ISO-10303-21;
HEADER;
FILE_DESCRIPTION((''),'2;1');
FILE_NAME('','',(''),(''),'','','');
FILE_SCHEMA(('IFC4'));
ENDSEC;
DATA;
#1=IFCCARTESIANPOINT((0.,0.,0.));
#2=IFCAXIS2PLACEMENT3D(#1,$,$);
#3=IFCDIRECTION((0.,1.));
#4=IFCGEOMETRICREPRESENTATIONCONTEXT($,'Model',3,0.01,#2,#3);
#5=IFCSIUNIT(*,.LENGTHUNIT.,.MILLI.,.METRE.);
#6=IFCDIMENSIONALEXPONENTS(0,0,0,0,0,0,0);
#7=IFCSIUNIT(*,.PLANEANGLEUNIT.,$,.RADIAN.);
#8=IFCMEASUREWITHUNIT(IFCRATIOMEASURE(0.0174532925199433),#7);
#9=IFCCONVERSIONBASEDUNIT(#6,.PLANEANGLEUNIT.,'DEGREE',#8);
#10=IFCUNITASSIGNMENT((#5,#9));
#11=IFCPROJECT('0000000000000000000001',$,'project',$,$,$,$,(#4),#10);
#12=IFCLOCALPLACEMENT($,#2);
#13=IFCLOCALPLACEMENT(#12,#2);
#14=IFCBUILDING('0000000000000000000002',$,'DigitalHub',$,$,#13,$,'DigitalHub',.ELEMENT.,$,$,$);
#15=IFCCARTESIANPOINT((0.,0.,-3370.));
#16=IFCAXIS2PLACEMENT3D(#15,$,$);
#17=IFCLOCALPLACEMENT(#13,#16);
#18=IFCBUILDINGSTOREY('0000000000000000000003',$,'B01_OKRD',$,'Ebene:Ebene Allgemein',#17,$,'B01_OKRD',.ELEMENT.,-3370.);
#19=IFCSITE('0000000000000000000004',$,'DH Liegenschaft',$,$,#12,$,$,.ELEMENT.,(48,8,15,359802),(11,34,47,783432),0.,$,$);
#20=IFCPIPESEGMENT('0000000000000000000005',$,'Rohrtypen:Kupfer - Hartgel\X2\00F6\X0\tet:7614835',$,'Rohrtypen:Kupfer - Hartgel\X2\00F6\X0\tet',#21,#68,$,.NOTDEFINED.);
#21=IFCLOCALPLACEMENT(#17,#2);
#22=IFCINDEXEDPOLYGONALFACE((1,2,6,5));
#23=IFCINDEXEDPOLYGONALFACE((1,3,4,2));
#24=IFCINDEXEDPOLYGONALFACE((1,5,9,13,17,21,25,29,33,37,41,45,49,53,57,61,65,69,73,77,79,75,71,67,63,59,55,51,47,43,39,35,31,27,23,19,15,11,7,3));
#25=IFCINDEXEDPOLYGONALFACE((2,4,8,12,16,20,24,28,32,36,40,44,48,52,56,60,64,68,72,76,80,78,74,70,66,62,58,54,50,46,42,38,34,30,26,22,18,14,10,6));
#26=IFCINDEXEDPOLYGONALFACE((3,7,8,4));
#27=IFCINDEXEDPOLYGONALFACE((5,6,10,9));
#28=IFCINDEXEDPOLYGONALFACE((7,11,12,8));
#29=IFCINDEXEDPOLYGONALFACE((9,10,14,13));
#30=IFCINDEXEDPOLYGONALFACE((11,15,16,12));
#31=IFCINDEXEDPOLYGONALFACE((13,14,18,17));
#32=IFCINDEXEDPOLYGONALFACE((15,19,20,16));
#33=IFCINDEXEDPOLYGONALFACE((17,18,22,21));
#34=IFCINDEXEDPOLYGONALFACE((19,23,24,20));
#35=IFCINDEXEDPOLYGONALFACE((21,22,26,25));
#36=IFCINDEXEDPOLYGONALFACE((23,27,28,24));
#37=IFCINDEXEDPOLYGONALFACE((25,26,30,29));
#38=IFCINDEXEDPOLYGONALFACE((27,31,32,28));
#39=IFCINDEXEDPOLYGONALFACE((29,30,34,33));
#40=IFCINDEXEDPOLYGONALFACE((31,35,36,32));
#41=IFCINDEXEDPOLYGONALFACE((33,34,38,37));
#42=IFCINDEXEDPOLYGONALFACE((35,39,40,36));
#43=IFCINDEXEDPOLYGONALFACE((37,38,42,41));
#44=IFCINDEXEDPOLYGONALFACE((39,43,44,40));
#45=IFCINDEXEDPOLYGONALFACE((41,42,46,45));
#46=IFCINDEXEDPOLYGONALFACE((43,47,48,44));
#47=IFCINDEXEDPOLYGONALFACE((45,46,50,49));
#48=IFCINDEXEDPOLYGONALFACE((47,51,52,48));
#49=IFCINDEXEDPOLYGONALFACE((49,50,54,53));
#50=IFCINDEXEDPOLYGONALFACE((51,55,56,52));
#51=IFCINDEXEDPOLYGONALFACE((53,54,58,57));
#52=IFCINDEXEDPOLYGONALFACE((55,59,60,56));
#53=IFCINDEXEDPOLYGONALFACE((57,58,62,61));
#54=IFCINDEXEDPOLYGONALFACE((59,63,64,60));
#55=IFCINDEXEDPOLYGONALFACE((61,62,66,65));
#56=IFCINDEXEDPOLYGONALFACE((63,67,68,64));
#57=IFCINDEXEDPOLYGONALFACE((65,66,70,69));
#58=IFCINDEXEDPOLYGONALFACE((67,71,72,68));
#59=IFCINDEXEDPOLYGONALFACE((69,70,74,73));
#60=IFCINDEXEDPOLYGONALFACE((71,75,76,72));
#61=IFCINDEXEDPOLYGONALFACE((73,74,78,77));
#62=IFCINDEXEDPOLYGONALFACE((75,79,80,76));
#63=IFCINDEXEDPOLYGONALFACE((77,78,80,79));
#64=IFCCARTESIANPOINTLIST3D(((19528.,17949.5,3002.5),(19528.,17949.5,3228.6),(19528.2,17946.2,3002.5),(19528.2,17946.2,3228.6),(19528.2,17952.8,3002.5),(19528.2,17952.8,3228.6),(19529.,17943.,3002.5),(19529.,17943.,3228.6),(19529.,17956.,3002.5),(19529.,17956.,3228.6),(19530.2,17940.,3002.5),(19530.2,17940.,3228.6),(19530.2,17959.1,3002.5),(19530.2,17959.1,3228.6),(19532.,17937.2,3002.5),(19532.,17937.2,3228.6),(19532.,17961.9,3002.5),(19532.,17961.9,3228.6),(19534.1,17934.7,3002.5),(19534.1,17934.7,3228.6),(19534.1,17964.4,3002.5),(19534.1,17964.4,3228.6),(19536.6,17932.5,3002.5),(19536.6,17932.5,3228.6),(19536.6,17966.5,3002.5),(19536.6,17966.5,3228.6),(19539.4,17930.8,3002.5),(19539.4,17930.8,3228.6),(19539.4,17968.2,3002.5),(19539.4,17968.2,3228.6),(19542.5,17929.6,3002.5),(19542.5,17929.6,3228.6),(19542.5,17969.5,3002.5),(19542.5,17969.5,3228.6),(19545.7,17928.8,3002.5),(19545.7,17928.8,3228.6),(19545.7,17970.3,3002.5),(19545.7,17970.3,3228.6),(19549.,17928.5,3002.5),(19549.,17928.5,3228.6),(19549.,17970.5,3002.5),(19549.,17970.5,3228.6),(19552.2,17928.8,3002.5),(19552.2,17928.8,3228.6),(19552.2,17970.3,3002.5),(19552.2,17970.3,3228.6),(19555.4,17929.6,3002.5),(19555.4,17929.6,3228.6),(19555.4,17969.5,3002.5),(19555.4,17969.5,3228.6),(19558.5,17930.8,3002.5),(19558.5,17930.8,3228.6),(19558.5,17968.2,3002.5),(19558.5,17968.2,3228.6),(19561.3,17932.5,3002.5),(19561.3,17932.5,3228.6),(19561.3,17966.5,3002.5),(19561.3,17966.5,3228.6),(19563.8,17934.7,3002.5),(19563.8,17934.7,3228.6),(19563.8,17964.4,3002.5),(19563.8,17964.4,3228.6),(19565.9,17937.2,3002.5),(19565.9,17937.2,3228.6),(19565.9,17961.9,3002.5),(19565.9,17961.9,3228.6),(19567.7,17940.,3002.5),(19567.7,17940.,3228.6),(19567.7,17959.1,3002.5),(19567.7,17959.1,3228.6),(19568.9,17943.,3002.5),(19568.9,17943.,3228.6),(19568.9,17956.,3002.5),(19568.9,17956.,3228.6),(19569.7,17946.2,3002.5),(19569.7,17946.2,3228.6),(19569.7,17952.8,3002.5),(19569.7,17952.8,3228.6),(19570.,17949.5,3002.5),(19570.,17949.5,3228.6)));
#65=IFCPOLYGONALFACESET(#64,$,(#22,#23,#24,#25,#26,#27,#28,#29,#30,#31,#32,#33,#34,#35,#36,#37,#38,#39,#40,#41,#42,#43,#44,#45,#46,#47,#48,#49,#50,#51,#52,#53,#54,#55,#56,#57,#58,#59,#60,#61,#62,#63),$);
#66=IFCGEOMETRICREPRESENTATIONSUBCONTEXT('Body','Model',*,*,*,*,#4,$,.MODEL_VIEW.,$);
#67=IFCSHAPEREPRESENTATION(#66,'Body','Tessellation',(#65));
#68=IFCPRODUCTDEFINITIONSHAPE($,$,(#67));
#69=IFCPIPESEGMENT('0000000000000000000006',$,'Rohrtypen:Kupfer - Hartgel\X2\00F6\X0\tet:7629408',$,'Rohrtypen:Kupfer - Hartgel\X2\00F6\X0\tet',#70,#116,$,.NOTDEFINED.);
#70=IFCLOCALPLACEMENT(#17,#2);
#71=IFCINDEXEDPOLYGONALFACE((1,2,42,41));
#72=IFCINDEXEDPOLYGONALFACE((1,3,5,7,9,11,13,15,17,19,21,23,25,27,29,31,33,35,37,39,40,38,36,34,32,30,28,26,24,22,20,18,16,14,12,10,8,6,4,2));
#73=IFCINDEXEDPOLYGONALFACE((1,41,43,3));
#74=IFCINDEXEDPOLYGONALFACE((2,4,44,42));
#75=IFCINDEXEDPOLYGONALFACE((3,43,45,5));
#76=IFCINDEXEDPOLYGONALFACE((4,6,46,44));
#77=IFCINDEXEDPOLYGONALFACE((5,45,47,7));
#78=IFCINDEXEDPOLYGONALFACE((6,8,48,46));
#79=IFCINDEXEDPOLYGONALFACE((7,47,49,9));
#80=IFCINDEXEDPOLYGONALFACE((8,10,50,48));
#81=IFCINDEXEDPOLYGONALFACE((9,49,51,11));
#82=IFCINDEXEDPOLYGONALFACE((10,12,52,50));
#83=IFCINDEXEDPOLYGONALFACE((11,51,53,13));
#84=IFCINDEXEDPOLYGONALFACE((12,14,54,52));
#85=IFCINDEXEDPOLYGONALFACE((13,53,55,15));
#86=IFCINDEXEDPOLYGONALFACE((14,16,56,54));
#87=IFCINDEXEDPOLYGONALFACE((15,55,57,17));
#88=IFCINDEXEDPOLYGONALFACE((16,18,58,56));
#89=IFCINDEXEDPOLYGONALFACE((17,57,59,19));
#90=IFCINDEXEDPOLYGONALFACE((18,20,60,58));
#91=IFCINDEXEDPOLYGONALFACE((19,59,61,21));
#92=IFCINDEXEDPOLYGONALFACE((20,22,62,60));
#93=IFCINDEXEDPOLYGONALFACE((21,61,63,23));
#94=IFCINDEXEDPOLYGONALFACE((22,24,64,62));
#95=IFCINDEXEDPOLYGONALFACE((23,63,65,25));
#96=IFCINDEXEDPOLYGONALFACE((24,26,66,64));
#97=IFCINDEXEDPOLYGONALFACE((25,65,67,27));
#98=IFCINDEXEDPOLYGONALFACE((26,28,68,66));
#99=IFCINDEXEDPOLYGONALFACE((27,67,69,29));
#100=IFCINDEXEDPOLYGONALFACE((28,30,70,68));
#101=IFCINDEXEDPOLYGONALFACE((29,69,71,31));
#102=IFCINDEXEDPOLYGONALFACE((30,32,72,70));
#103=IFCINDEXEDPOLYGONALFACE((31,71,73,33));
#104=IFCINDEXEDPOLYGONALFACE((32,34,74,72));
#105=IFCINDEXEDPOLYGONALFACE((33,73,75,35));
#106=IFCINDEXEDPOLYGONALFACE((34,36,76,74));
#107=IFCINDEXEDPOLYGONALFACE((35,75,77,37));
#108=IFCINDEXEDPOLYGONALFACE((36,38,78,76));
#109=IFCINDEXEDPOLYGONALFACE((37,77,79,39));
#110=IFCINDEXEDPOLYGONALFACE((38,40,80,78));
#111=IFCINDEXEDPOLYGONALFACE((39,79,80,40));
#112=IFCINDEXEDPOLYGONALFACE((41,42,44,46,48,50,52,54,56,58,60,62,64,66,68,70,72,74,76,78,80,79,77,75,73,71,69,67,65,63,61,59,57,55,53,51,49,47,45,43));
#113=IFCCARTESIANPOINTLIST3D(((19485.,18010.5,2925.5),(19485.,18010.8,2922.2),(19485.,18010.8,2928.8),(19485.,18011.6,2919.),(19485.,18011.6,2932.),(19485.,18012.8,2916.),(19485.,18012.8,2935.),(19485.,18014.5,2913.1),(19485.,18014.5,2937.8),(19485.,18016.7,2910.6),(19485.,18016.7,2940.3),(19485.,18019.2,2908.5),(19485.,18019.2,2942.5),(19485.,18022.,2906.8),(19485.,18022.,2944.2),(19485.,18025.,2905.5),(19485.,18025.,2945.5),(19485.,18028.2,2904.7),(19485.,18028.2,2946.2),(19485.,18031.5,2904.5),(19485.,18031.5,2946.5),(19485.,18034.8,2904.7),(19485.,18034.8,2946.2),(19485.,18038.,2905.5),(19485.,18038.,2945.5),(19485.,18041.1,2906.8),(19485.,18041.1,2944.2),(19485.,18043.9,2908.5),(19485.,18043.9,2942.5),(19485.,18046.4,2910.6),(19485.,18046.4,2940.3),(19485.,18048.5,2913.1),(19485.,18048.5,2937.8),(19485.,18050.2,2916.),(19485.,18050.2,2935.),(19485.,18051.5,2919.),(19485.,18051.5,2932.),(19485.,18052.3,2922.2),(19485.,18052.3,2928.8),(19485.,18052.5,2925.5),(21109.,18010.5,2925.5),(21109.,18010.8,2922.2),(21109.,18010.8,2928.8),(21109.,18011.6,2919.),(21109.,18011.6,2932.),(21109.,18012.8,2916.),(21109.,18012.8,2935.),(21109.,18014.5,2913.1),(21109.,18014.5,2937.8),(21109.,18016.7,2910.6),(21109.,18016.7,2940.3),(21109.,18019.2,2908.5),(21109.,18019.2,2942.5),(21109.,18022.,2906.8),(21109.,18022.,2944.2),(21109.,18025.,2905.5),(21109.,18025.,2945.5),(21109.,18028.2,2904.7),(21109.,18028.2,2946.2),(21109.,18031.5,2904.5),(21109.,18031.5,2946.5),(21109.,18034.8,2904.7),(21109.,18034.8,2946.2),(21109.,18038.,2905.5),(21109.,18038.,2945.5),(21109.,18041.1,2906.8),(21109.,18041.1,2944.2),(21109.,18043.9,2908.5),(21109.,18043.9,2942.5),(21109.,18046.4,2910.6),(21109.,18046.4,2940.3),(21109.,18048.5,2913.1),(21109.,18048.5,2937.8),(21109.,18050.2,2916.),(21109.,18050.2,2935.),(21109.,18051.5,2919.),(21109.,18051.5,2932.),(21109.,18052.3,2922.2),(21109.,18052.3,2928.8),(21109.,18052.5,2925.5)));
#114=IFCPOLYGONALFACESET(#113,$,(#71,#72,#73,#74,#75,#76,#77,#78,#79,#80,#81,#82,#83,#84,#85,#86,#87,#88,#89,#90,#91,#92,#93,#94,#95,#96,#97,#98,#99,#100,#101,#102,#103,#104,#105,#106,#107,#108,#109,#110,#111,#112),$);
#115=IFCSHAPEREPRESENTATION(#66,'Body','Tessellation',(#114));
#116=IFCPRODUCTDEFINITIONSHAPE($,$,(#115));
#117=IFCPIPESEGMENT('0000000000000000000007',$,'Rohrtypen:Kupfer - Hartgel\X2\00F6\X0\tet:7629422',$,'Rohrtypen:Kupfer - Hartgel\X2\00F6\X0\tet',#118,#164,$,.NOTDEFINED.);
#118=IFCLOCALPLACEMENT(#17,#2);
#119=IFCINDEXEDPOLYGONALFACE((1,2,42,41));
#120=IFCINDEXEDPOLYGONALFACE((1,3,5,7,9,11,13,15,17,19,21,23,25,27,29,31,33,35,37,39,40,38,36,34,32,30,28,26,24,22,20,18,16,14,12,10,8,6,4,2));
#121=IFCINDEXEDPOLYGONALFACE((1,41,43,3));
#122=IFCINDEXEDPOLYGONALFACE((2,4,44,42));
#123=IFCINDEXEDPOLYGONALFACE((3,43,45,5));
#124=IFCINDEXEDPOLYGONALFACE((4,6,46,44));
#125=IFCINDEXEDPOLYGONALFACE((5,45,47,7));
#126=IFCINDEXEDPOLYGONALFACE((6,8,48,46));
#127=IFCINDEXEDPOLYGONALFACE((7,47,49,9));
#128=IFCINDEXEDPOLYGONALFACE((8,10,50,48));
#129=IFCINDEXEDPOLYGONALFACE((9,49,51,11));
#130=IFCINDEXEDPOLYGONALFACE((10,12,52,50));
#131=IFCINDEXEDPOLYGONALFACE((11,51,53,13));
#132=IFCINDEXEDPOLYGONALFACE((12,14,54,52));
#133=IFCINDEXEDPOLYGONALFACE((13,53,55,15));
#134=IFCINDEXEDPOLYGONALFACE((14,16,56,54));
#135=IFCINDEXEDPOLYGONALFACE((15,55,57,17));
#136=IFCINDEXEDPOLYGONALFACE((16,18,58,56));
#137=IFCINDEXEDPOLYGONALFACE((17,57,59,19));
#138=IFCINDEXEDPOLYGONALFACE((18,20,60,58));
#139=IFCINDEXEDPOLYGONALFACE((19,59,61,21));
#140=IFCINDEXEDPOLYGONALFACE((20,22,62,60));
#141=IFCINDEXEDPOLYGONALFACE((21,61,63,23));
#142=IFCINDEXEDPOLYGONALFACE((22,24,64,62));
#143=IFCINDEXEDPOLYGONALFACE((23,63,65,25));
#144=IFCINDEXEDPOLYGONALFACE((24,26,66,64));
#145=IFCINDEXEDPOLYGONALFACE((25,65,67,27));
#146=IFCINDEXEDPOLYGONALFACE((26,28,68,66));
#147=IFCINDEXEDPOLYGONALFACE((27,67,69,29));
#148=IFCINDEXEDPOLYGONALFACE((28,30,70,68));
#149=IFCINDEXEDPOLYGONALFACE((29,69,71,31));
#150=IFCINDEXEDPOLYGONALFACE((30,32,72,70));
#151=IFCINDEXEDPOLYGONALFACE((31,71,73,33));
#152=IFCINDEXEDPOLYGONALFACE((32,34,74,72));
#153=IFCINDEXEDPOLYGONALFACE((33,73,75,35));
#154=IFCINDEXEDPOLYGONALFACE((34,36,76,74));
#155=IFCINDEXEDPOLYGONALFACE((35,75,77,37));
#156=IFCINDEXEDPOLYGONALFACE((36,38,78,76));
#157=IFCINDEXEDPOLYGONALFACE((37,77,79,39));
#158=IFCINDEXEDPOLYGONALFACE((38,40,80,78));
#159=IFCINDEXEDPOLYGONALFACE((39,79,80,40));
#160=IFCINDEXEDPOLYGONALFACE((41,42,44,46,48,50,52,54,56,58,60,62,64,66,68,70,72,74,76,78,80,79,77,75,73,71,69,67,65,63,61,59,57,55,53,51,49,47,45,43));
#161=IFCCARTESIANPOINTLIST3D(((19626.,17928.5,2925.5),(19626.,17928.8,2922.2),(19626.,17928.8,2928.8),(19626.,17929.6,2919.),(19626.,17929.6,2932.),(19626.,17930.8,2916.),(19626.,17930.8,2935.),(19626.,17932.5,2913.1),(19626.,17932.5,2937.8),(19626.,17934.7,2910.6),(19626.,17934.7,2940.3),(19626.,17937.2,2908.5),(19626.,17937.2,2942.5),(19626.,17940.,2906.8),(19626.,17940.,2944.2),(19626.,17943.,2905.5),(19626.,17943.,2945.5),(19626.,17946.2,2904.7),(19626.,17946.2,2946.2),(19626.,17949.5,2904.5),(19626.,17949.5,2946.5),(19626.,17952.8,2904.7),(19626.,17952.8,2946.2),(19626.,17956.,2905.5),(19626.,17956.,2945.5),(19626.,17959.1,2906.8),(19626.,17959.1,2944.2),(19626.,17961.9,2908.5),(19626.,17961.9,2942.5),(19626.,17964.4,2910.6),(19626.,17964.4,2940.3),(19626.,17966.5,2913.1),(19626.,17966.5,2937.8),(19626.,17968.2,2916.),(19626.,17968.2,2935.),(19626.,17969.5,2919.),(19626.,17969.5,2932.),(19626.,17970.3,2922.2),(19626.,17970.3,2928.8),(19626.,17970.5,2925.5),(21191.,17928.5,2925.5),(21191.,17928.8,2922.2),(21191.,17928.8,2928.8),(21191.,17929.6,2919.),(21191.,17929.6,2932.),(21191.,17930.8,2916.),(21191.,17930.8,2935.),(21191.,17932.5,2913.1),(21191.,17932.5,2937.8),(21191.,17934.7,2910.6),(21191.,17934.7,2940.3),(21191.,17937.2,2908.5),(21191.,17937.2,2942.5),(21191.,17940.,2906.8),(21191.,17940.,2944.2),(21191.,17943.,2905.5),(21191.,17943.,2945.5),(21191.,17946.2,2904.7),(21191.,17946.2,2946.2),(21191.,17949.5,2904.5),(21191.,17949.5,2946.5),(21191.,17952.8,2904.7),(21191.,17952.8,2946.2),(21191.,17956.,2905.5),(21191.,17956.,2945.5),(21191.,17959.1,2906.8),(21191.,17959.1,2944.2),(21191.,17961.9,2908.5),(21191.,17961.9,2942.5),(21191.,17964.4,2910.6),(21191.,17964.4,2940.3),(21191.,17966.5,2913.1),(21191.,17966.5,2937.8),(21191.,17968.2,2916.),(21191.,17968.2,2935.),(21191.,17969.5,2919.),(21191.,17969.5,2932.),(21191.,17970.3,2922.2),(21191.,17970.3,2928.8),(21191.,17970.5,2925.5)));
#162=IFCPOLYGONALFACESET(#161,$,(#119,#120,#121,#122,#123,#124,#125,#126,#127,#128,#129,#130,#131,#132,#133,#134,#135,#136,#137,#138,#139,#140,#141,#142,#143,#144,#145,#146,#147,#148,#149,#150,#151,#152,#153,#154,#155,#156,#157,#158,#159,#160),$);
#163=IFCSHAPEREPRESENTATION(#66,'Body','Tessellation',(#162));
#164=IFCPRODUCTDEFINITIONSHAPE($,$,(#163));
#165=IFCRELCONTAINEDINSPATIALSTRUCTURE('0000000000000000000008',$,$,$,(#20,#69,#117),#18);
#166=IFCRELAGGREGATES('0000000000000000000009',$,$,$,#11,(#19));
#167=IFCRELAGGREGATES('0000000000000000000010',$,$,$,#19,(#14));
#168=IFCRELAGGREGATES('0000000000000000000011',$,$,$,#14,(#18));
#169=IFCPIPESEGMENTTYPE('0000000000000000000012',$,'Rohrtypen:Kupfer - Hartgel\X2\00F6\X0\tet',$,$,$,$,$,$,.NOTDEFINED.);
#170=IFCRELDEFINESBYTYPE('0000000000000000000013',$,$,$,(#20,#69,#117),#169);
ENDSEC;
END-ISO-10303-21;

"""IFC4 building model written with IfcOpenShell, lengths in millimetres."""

from ifc_helpers import new_model, entity, si_unit, converted_unit, direction, frame, origin, place, context, subcontext, project, spatial, indexed_curve, outline, extrude, type_object, element, save


model = new_model("IFC4")

# Units and contexts
model_context = context("Model", 3, precision=0.01, world=origin(), true_north=direction((0.0, 1.0)))
body_context = subcontext(model_context, "Body", "Model", "MODEL_VIEW")
ifc_project = project(units=[si_unit("LENGTHUNIT", "METRE", prefix="MILLI"), converted_unit("PLANEANGLEUNIT", "DEGREE", entity("IfcRatioMeasure", 0.0174532925199433), si_unit("PLANEANGLEUNIT", "RADIAN"), dimensions=[0, 0, 0, 0, 0, 0, 0])], contexts=[model_context])

# Site, building, storey
site_placement = place(None, origin())
site = spatial("IfcSite", under=ifc_project, at=site_placement, Name="DH Liegenschaft", CompositionType="ELEMENT", RefLatitude=(48, 8, 15, 359802), RefLongitude=(11, 34, 47, 783432), RefElevation=0.0)
building_placement = place(site_placement, origin())
building = spatial("IfcBuilding", under=site, at=building_placement, Name="DigitalHub", LongName="DigitalHub", CompositionType="ELEMENT")
storey_placement = place(building_placement, frame((0.0, 0.0, -3370.0)))
storey = spatial("IfcBuildingStorey", under=building, at=storey_placement, Name="B01_OKRD", ObjectType="Ebene:Ebene Allgemein", LongName="B01_OKRD", CompositionType="ELEMENT", Elevation=-3370.0)

# Pipe segments
pipe_segment_type = type_object("IfcPipeSegmentType", Name="Rohrtypen:Kupfer - Hartgelötet", PredefinedType="NOTDEFINED")
pipe_segment_1_placement = place(storey_placement, frame((19526.4, 17926.9, 3002.5)))
element("IfcPipeSegment", 1, at=pipe_segment_1_placement, inside=storey, type_object=pipe_segment_type, Name="Rohrtypen:Kupfer - Hartgelötet:7614835", ObjectType="Rohrtypen:Kupfer - Hartgelötet", PredefinedType="NOTDEFINED", context=body_context, shape_type="SweptSolid", body=[
    extrude(outline(indexed_curve([(21.0, 0.0), (20.7, 3.3), (20.0, 6.5), (18.7, 9.5), (17.0, 12.3), (14.8, 14.8), (12.3, 17.0), (9.5, 18.7), (6.5, 20.0), (3.3, 20.7), (0.0, 21.0), (-3.3, 20.7), (-6.5, 20.0), (-9.5, 18.7), (-12.3, 17.0), (-14.8, 14.8), (-17.0, 12.3), (-18.7, 9.5), (-20.0, 6.5), (-20.7, 3.3), (-21.0, 0.0), (-20.7, -3.3), (-20.0, -6.5), (-18.7, -9.5), (-17.0, -12.3), (-14.8, -14.8), (-12.3, -17.0), (-9.5, -18.7), (-6.5, -20.0), (-3.3, -20.7), (0.0, -21.0), (3.3, -20.7), (6.5, -20.0), (9.5, -18.7), (12.3, -17.0), (14.8, -14.8), (17.0, -12.3), (18.7, -9.5), (20.0, -6.5), (20.7, -3.3), (21.0, 0.0)], self_intersect=False)), frame((22.6, 22.6, 0.0)), (0.0, 0.0, 1.0), 226.1),
])
pipe_segment_2_placement = place(storey_placement, frame((19485.0, 18008.9, 2902.9)))
element("IfcPipeSegment", 2, at=pipe_segment_2_placement, inside=storey, type_object=pipe_segment_type, Name="Rohrtypen:Kupfer - Hartgelötet:7629408", ObjectType="Rohrtypen:Kupfer - Hartgelötet", PredefinedType="NOTDEFINED", context=body_context, shape_type="SweptSolid", body=[
    extrude(outline(indexed_curve([(21.0, 0.0), (20.7, 3.3), (20.0, 6.5), (18.7, 9.5), (17.0, 12.3), (14.8, 14.8), (12.3, 17.0), (9.5, 18.7), (6.5, 20.0), (3.3, 20.7), (0.0, 21.0), (-3.3, 20.7), (-6.5, 20.0), (-9.5, 18.7), (-12.3, 17.0), (-14.8, 14.8), (-17.0, 12.3), (-18.7, 9.5), (-20.0, 6.5), (-20.7, 3.3), (-21.0, 0.0), (-20.7, -3.3), (-20.0, -6.5), (-18.7, -9.5), (-17.0, -12.3), (-14.8, -14.8), (-12.3, -17.0), (-9.5, -18.7), (-6.5, -20.0), (-3.3, -20.7), (0.0, -21.0), (3.3, -20.7), (6.5, -20.0), (9.5, -18.7), (12.3, -17.0), (14.8, -14.8), (17.0, -12.3), (18.7, -9.5), (20.0, -6.5), (20.7, -3.3), (21.0, 0.0)], self_intersect=False)), frame((0.0, 22.6, 22.6), z_axis=(1.0, 0.0, 0.0), x_axis=(0.0, 1.0, 0.0)), (0.0, 0.0, 1.0), 1624.0),
])
pipe_segment_3_placement = place(storey_placement, frame((19626.0, 17926.9, 2902.9)))
element("IfcPipeSegment", 3, at=pipe_segment_3_placement, inside=storey, type_object=pipe_segment_type, Name="Rohrtypen:Kupfer - Hartgelötet:7629422", ObjectType="Rohrtypen:Kupfer - Hartgelötet", PredefinedType="NOTDEFINED", context=body_context, shape_type="SweptSolid", body=[
    extrude(outline(indexed_curve([(21.0, 0.0), (20.7, 3.3), (20.0, 6.5), (18.7, 9.5), (17.0, 12.3), (14.8, 14.8), (12.3, 17.0), (9.5, 18.7), (6.5, 20.0), (3.3, 20.7), (0.0, 21.0), (-3.3, 20.7), (-6.5, 20.0), (-9.5, 18.7), (-12.3, 17.0), (-14.8, 14.8), (-17.0, 12.3), (-18.7, 9.5), (-20.0, 6.5), (-20.7, 3.3), (-21.0, 0.0), (-20.7, -3.3), (-20.0, -6.5), (-18.7, -9.5), (-17.0, -12.3), (-14.8, -14.8), (-12.3, -17.0), (-9.5, -18.7), (-6.5, -20.0), (-3.3, -20.7), (0.0, -21.0), (3.3, -20.7), (6.5, -20.0), (9.5, -18.7), (12.3, -17.0), (14.8, -14.8), (17.0, -12.3), (18.7, -9.5), (20.0, -6.5), (20.7, -3.3), (21.0, 0.0)], self_intersect=False)), frame((0.0, 22.6, 22.6), z_axis=(1.0, 0.0, 0.0), x_axis=(0.0, 1.0, 0.0)), (0.0, 0.0, 1.0), 1565.0),
])

save(model, "model.ifc")
